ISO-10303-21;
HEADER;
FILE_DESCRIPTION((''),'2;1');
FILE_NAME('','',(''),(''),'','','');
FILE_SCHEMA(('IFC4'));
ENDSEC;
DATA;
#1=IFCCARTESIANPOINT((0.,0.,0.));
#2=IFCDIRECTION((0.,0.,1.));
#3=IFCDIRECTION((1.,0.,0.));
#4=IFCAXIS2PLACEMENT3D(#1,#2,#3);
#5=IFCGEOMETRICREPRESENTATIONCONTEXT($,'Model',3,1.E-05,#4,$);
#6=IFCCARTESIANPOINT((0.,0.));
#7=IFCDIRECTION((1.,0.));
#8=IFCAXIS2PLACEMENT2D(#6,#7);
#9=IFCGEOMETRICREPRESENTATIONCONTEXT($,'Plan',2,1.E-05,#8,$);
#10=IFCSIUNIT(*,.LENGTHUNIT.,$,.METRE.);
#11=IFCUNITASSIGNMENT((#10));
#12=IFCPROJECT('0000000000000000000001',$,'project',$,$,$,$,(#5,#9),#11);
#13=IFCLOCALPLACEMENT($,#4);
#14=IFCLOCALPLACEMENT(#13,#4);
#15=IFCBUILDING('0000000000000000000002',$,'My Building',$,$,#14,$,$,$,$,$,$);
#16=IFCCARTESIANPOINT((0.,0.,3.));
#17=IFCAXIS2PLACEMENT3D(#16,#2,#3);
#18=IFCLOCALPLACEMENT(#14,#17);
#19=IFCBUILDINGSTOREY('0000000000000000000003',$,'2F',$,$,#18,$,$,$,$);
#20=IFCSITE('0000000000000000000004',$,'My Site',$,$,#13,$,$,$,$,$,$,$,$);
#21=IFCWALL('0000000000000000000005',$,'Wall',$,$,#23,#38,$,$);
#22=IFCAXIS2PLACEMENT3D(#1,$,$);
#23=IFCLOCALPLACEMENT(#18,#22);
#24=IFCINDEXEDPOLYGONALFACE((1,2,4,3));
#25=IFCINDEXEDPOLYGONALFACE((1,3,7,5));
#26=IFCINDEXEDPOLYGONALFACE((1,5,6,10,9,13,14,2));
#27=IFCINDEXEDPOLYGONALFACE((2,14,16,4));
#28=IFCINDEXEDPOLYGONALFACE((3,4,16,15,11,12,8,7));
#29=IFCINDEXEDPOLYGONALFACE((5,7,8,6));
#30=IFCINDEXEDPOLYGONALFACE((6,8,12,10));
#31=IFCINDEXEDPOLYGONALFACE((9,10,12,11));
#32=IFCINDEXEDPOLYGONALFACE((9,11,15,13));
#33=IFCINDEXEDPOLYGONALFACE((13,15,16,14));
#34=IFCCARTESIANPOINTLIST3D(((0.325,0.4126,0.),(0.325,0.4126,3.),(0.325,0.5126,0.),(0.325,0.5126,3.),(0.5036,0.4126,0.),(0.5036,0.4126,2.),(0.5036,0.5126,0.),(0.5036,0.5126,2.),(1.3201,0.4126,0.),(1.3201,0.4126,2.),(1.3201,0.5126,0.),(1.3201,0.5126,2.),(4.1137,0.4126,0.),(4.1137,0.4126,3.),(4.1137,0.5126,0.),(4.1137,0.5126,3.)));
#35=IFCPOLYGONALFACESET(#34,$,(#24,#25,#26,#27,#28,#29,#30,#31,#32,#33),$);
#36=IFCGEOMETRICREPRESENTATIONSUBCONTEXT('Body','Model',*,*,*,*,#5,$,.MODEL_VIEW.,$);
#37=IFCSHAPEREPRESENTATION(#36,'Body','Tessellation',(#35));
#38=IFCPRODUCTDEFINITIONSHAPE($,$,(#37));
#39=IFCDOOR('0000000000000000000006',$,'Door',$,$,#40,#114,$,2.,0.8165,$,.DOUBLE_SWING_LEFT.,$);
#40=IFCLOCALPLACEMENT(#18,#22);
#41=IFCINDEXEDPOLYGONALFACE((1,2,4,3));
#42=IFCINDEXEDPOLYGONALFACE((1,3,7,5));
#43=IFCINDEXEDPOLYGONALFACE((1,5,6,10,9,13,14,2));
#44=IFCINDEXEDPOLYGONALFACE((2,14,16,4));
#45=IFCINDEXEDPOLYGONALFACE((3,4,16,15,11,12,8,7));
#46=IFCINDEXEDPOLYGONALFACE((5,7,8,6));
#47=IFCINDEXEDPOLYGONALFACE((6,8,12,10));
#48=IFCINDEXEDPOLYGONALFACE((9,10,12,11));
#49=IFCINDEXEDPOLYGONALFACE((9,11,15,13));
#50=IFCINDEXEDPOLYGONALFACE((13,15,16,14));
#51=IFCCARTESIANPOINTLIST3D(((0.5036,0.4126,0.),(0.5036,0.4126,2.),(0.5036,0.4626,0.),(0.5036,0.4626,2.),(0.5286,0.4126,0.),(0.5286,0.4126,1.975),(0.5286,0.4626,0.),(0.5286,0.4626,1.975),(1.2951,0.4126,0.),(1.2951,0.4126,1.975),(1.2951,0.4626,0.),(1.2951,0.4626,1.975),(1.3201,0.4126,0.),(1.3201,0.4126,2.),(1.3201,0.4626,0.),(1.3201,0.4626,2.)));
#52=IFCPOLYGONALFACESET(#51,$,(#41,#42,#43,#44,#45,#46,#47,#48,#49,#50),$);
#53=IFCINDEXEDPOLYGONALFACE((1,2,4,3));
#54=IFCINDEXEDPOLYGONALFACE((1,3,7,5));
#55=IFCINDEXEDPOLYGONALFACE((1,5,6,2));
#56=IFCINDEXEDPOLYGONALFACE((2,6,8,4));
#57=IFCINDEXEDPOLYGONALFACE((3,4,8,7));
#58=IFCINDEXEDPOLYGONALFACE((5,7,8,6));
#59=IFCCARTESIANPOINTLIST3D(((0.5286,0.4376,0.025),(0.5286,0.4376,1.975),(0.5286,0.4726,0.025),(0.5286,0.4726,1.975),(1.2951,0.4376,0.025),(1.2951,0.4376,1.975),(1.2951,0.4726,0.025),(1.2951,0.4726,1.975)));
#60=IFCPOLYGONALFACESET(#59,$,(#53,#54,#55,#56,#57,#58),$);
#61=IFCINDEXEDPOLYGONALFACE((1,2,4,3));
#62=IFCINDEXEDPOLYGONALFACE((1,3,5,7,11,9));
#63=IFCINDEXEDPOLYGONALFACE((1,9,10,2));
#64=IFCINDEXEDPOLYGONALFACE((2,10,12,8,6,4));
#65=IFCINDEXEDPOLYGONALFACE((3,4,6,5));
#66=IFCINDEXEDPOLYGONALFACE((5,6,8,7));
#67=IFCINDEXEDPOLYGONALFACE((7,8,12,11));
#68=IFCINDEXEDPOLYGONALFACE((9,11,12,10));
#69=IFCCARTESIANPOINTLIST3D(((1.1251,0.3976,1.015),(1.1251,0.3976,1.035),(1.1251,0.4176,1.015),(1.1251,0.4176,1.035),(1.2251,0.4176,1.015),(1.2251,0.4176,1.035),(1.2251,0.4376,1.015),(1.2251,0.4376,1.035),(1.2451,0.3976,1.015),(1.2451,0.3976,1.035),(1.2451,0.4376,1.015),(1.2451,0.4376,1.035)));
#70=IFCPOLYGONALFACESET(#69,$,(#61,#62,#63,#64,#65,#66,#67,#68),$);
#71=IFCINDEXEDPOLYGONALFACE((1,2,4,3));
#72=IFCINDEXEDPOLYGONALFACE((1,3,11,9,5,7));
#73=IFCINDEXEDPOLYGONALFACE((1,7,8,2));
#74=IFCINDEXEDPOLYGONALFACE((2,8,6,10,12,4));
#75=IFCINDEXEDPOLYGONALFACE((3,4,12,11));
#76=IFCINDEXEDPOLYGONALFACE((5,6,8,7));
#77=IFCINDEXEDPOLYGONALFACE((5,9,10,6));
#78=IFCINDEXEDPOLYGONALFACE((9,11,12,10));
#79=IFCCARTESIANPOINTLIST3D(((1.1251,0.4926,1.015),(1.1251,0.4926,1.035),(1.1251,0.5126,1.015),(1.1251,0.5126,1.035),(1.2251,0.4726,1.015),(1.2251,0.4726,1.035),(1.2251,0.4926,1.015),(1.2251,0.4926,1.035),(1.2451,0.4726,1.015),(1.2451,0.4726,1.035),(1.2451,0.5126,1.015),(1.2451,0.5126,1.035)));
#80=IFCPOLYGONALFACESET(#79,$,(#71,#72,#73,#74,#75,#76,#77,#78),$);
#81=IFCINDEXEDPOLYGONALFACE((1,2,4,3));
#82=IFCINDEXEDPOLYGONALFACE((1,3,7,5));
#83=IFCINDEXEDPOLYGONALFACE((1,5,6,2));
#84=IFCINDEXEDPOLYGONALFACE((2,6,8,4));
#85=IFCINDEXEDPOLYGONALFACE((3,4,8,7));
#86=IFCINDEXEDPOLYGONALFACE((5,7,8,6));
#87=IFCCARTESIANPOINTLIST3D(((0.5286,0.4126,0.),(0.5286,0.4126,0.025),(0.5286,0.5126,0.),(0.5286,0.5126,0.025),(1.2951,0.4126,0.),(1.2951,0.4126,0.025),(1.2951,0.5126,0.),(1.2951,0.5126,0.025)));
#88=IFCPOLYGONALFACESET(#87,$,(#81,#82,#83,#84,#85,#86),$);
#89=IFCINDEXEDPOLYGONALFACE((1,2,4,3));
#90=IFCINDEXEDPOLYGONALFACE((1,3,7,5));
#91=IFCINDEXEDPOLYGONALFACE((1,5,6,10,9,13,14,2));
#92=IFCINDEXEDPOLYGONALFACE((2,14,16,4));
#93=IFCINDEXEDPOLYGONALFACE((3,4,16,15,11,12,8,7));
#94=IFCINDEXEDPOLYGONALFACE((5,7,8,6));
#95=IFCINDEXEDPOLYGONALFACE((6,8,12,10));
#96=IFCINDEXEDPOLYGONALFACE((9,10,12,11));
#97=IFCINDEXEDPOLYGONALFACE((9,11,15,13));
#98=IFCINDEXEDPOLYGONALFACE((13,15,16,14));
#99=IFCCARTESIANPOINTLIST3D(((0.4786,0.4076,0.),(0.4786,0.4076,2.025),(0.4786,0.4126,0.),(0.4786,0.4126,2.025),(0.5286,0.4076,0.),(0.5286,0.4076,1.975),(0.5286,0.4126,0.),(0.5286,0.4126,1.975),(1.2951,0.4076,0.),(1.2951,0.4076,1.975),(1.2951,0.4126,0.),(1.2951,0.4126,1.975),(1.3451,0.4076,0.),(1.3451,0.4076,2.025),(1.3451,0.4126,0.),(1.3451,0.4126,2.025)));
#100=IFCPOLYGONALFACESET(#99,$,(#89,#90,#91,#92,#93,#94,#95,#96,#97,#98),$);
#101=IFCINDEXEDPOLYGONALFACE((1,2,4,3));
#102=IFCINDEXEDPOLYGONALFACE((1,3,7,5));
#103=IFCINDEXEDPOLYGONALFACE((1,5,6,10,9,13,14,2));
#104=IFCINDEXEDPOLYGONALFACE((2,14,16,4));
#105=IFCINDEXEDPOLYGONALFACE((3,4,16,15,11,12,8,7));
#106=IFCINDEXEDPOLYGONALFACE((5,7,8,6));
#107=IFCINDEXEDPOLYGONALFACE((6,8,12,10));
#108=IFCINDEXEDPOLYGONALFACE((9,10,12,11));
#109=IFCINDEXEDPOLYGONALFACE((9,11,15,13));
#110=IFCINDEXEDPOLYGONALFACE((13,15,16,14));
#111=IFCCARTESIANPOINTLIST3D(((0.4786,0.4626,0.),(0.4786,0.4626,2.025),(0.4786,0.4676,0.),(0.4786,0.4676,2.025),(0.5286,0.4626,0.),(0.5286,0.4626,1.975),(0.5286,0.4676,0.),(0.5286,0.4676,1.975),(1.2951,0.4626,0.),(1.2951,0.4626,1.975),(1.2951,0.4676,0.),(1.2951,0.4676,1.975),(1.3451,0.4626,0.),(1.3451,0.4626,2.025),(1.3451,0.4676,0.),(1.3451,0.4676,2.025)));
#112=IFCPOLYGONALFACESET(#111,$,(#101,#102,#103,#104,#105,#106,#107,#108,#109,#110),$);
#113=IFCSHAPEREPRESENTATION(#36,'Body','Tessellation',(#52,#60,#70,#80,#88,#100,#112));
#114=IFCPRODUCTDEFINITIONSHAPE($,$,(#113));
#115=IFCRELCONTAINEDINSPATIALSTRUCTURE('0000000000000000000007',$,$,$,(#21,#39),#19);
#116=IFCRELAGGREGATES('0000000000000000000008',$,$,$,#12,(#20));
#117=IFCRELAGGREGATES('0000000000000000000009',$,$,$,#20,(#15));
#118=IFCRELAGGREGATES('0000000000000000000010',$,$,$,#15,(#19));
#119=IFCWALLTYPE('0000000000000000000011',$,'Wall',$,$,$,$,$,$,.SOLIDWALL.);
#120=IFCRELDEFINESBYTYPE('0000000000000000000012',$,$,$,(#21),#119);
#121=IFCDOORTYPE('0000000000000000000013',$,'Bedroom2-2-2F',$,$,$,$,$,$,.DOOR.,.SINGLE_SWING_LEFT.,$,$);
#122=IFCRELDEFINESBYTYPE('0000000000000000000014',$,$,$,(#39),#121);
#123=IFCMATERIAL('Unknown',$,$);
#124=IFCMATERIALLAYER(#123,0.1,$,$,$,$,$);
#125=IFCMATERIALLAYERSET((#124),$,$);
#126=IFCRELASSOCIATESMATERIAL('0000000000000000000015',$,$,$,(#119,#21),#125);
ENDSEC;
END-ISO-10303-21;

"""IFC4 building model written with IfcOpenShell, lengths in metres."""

from ifc_helpers import new_model, entity, si_unit, frame, origin_with_axes, origin_2d_with_axis, place, context, subcontext, project, spatial, line, indexed_curve, outline, extrude, shape, source, transform, mapped, material, layer, layer_set, layer_usage, type_object, type_shapes, element, fill, save


model = new_model("IFC4")

# Units and contexts
model_context = context("Model", 3, precision=1e-05, world=origin_with_axes())
plan_context = context("Plan", 2, precision=1e-05, world=origin_2d_with_axis())
body_context_1 = subcontext(model_context, "Body", "Model", "MODEL_VIEW")
body_context_2 = subcontext(plan_context, "Body", "Plan", "PLAN_VIEW")
ifc_project = project(units=[si_unit("LENGTHUNIT", "METRE")], contexts=[model_context, plan_context])

# Site, building, storey
site_placement = place(None, origin_with_axes())
site = spatial("IfcSite", under=ifc_project, at=site_placement, Name="My Site")
building_placement = place(site_placement, origin_with_axes())
building = spatial("IfcBuilding", under=site, at=building_placement, Name="My Building")
storey_placement = place(building_placement, frame((0.0, 0.0, 3.0), z_axis=(0.0, 0.0, 1.0), x_axis=(1.0, 0.0, 0.0)))
storey = spatial("IfcBuildingStorey", under=building, at=storey_placement, Name="2F")

# Shared definitions
ifc_material = material(Name="Unknown")

# Shared definitions
ifc_layer_1 = layer(ifc_material, 0.1)
ifc_layer_set_1 = layer_set([ifc_layer_1])
wall_type = type_object("IfcWallType", Name="Wall", PredefinedType="SOLIDWALL", material=ifc_layer_set_1)

# Wall, opening, door
ifc_layer_usage_1 = layer_usage(ifc_layer_set_1, "AXIS2", "POSITIVE", 0.0)
wall_1_placement = place(storey_placement, frame((0.325, 0.4126, 0.0), z_axis=(0.0, 0.0, 1.0), x_axis=(1.0, 0.0, 0.0)))
wall_1 = element("IfcWall", 1, at=wall_1_placement, inside=storey, type_object=wall_type, material=ifc_layer_usage_1, Name="Wall", context=body_context_1, shape_type="SweptSolid", body=[
    extrude(outline(indexed_curve([(0.0, 0.0), (0.0, 0.1), (3.7887, 0.1), (3.7887, 0.0)], segments=[line(1, 2, 3, 4, 1)])), origin_with_axes(), (0.0, 0.0, 1.0), 3.0),
])
shared_shape_1 = source(origin_with_axes(), body_context_1, "Body", "SweptSolid", [
    extrude(outline(indexed_curve([(0.0, 0.0), (0.8165, 0.0), (0.8165, 2.0), (0.0, 2.0)], segments=[line(1, 2, 3, 4, 1)])), frame((0.0, -0.6, 0.0), z_axis=(0.0, -1.0, 0.0), x_axis=(1.0, 0.0, 0.0)), (0.0, 0.0, -1.0), 1.2),
])
opening_1_placement = place(wall_1_placement, frame((0.1786, 0.0, 0.0), z_axis=(0.0, 0.0, 1.0), x_axis=(1.0, 0.0, 0.0)))
opening_1 = element("IfcOpeningElement", 2, at=opening_1_placement, cuts=wall_1, PredefinedType="OPENING", context=body_context_1, shape_type="MappedRepresentation", body=[
    mapped(shared_shape_1, transform((0.0, 0.0, 0.0), x_axis=(1.0, 0.0, 0.0), y_axis=(0.0, 1.0, 0.0), z_axis=(0.0, 0.0, 1.0), scale=1.0)),
])
door_type_1 = type_object("IfcDoorType", Name="Bedroom2-2-2F", OperationType="SINGLE_SWING_LEFT", PredefinedType="DOOR")
shared_shape_2 = source(origin_with_axes(), body_context_1, "Body", "SweptSolid", [
    extrude(outline(indexed_curve([(0.0, 0.0), (0.0, 2.0), (0.8165, 2.0), (0.8165, 0.0), (0.7915, 0.0), (0.7915, 1.975), (0.025, 1.975), (0.025, 0.0)], segments=[line(1, 2, 3, 4, 5, 6, 7, 8, 1)])), frame((0.0, 0.0, 0.0), z_axis=(0.0, -1.0, 0.0), x_axis=(1.0, 0.0, 0.0)), (0.0, 0.0, -1.0), 0.05),
    extrude(outline(indexed_curve([(0.0, 0.0), (0.7665, 0.0), (0.7665, 0.035), (0.0, 0.035)], segments=[line(1, 2, 3, 4, 1)])), frame((0.025, 0.025, 0.025), z_axis=(0.0, 0.0, 1.0), x_axis=(1.0, 0.0, 0.0)), (0.0, 0.0, 1.0), 1.95),
    extrude(outline(indexed_curve([(0.0, 0.0), (0.0, -0.04), (-0.12, -0.04), (-0.12, -0.02), (-0.02, -0.02), (-0.02, 0.0)], segments=[line(1, 2, 3, 4, 5, 6, 1)])), frame((0.7415, 0.025, 1.015), z_axis=(0.0, 0.0, 1.0), x_axis=(1.0, 0.0, 0.0)), (0.0, 0.0, 1.0), 0.02),
    extrude(outline(indexed_curve([(0.0, 0.0), (0.0, 0.04), (-0.12, 0.04), (-0.12, 0.02), (-0.02, 0.02), (-0.02, 0.0)], segments=[line(1, 2, 3, 4, 5, 6, 1)])), frame((0.7415, 0.06, 1.015), z_axis=(0.0, 0.0, 1.0), x_axis=(1.0, 0.0, 0.0)), (0.0, 0.0, 1.0), 0.02),
    extrude(outline(indexed_curve([(0.0, 0.0), (0.7665, 0.0), (0.7665, 0.1), (0.0, 0.1)], segments=[line(1, 2, 3, 4, 1)])), frame((0.025, 0.0, 0.0), z_axis=(0.0, 0.0, 1.0), x_axis=(1.0, 0.0, 0.0)), (0.0, 0.0, 1.0), 0.025),
    extrude(outline(indexed_curve([(0.0, 0.0), (0.0, 2.025), (0.8665, 2.025), (0.8665, 0.0), (0.8165, 0.0), (0.8165, 1.975), (0.05, 1.975), (0.05, 0.0)], segments=[line(1, 2, 3, 4, 5, 6, 7, 8, 1)])), frame((-0.025, -0.005, 0.0), z_axis=(0.0, -1.0, 0.0), x_axis=(1.0, 0.0, 0.0)), (0.0, 0.0, -1.0), 0.005),
    extrude(outline(indexed_curve([(0.0, 0.0), (0.0, 2.025), (0.8665, 2.025), (0.8665, 0.0), (0.8165, 0.0), (0.8165, 1.975), (0.05, 1.975), (0.05, 0.0)], segments=[line(1, 2, 3, 4, 5, 6, 7, 8, 1)])), frame((-0.025, 0.05, 0.0), z_axis=(0.0, -1.0, 0.0), x_axis=(1.0, 0.0, 0.0)), (0.0, 0.0, -1.0), 0.005),
])
shared_shape_3 = source(origin_with_axes(), body_context_2, "Body", "Curve2D", [
    entity("IfcIndexedPolyCurve", entity("IfcCartesianPointList2D", [[0.0, 0.0], [0.025, 0.0], [0.025, 0.05], [0.0, 0.05]]), [entity("IfcLineIndex", [1, 2, 3, 4, 1])]),
    entity("IfcIndexedPolyCurve", entity("IfcCartesianPointList2D", [[0.8165, 0.0], [0.7915, 0.0], [0.7915, 0.05], [0.8165, 0.05]]), [entity("IfcLineIndex", [1, 2, 3, 4, 1])]),
    entity("IfcIndexedPolyCurve", entity("IfcCartesianPointList2D", [[0.025, 0.05], [0.025, -0.7165], [0.06, -0.7165]])),
    entity("IfcTrimmedCurve", entity("IfcEllipse", entity("IfcAxis2Placement2D", entity("IfcCartesianPoint", [0.06, 0.05]), entity("IfcDirection", [1.0, 0.0])), 0.7315, 0.7665), [entity("IfcCartesianPoint", [0.06, -0.7165])], [entity("IfcCartesianPoint", [0.06, 0.8165])], True, "CARTESIAN"),
    entity("IfcIndexedPolyCurve", entity("IfcCartesianPointList2D", [[0.025, 0.05], [0.06, 0.05], [0.06, 0.8165], [0.025, 0.8165]]), [entity("IfcLineIndex", [1, 2, 3, 4, 1])]),
])
type_shapes(door_type_1, [shared_shape_2, shared_shape_3])
door_1_placement = place(opening_1_placement, origin_with_axes())
door_1 = element("IfcDoor", 3, at=door_1_placement, inside=storey, type_object=door_type_1, Name="Door", OperationType="DOUBLE_SWING_LEFT", OverallHeight=2.0, OverallWidth=0.8165, shapes=[
    shape(body_context_1, "Body", "MappedRepresentation", [mapped(shared_shape_2, transform((0.0, 0.0, 0.0), x_axis=(1.0, 0.0, 0.0), y_axis=(0.0, 1.0, 0.0), z_axis=(0.0, 0.0, 1.0), scale=1.0))]),
    shape(body_context_2, "Body", "MappedRepresentation", [mapped(shared_shape_3, transform((0.0, 0.0, 0.0), x_axis=(1.0, 0.0, 0.0), y_axis=(0.0, 1.0, 0.0), z_axis=(0.0, 0.0, 1.0), scale=1.0))]),
])
fill(opening_1, door_1)

save(model, "model.ifc")
